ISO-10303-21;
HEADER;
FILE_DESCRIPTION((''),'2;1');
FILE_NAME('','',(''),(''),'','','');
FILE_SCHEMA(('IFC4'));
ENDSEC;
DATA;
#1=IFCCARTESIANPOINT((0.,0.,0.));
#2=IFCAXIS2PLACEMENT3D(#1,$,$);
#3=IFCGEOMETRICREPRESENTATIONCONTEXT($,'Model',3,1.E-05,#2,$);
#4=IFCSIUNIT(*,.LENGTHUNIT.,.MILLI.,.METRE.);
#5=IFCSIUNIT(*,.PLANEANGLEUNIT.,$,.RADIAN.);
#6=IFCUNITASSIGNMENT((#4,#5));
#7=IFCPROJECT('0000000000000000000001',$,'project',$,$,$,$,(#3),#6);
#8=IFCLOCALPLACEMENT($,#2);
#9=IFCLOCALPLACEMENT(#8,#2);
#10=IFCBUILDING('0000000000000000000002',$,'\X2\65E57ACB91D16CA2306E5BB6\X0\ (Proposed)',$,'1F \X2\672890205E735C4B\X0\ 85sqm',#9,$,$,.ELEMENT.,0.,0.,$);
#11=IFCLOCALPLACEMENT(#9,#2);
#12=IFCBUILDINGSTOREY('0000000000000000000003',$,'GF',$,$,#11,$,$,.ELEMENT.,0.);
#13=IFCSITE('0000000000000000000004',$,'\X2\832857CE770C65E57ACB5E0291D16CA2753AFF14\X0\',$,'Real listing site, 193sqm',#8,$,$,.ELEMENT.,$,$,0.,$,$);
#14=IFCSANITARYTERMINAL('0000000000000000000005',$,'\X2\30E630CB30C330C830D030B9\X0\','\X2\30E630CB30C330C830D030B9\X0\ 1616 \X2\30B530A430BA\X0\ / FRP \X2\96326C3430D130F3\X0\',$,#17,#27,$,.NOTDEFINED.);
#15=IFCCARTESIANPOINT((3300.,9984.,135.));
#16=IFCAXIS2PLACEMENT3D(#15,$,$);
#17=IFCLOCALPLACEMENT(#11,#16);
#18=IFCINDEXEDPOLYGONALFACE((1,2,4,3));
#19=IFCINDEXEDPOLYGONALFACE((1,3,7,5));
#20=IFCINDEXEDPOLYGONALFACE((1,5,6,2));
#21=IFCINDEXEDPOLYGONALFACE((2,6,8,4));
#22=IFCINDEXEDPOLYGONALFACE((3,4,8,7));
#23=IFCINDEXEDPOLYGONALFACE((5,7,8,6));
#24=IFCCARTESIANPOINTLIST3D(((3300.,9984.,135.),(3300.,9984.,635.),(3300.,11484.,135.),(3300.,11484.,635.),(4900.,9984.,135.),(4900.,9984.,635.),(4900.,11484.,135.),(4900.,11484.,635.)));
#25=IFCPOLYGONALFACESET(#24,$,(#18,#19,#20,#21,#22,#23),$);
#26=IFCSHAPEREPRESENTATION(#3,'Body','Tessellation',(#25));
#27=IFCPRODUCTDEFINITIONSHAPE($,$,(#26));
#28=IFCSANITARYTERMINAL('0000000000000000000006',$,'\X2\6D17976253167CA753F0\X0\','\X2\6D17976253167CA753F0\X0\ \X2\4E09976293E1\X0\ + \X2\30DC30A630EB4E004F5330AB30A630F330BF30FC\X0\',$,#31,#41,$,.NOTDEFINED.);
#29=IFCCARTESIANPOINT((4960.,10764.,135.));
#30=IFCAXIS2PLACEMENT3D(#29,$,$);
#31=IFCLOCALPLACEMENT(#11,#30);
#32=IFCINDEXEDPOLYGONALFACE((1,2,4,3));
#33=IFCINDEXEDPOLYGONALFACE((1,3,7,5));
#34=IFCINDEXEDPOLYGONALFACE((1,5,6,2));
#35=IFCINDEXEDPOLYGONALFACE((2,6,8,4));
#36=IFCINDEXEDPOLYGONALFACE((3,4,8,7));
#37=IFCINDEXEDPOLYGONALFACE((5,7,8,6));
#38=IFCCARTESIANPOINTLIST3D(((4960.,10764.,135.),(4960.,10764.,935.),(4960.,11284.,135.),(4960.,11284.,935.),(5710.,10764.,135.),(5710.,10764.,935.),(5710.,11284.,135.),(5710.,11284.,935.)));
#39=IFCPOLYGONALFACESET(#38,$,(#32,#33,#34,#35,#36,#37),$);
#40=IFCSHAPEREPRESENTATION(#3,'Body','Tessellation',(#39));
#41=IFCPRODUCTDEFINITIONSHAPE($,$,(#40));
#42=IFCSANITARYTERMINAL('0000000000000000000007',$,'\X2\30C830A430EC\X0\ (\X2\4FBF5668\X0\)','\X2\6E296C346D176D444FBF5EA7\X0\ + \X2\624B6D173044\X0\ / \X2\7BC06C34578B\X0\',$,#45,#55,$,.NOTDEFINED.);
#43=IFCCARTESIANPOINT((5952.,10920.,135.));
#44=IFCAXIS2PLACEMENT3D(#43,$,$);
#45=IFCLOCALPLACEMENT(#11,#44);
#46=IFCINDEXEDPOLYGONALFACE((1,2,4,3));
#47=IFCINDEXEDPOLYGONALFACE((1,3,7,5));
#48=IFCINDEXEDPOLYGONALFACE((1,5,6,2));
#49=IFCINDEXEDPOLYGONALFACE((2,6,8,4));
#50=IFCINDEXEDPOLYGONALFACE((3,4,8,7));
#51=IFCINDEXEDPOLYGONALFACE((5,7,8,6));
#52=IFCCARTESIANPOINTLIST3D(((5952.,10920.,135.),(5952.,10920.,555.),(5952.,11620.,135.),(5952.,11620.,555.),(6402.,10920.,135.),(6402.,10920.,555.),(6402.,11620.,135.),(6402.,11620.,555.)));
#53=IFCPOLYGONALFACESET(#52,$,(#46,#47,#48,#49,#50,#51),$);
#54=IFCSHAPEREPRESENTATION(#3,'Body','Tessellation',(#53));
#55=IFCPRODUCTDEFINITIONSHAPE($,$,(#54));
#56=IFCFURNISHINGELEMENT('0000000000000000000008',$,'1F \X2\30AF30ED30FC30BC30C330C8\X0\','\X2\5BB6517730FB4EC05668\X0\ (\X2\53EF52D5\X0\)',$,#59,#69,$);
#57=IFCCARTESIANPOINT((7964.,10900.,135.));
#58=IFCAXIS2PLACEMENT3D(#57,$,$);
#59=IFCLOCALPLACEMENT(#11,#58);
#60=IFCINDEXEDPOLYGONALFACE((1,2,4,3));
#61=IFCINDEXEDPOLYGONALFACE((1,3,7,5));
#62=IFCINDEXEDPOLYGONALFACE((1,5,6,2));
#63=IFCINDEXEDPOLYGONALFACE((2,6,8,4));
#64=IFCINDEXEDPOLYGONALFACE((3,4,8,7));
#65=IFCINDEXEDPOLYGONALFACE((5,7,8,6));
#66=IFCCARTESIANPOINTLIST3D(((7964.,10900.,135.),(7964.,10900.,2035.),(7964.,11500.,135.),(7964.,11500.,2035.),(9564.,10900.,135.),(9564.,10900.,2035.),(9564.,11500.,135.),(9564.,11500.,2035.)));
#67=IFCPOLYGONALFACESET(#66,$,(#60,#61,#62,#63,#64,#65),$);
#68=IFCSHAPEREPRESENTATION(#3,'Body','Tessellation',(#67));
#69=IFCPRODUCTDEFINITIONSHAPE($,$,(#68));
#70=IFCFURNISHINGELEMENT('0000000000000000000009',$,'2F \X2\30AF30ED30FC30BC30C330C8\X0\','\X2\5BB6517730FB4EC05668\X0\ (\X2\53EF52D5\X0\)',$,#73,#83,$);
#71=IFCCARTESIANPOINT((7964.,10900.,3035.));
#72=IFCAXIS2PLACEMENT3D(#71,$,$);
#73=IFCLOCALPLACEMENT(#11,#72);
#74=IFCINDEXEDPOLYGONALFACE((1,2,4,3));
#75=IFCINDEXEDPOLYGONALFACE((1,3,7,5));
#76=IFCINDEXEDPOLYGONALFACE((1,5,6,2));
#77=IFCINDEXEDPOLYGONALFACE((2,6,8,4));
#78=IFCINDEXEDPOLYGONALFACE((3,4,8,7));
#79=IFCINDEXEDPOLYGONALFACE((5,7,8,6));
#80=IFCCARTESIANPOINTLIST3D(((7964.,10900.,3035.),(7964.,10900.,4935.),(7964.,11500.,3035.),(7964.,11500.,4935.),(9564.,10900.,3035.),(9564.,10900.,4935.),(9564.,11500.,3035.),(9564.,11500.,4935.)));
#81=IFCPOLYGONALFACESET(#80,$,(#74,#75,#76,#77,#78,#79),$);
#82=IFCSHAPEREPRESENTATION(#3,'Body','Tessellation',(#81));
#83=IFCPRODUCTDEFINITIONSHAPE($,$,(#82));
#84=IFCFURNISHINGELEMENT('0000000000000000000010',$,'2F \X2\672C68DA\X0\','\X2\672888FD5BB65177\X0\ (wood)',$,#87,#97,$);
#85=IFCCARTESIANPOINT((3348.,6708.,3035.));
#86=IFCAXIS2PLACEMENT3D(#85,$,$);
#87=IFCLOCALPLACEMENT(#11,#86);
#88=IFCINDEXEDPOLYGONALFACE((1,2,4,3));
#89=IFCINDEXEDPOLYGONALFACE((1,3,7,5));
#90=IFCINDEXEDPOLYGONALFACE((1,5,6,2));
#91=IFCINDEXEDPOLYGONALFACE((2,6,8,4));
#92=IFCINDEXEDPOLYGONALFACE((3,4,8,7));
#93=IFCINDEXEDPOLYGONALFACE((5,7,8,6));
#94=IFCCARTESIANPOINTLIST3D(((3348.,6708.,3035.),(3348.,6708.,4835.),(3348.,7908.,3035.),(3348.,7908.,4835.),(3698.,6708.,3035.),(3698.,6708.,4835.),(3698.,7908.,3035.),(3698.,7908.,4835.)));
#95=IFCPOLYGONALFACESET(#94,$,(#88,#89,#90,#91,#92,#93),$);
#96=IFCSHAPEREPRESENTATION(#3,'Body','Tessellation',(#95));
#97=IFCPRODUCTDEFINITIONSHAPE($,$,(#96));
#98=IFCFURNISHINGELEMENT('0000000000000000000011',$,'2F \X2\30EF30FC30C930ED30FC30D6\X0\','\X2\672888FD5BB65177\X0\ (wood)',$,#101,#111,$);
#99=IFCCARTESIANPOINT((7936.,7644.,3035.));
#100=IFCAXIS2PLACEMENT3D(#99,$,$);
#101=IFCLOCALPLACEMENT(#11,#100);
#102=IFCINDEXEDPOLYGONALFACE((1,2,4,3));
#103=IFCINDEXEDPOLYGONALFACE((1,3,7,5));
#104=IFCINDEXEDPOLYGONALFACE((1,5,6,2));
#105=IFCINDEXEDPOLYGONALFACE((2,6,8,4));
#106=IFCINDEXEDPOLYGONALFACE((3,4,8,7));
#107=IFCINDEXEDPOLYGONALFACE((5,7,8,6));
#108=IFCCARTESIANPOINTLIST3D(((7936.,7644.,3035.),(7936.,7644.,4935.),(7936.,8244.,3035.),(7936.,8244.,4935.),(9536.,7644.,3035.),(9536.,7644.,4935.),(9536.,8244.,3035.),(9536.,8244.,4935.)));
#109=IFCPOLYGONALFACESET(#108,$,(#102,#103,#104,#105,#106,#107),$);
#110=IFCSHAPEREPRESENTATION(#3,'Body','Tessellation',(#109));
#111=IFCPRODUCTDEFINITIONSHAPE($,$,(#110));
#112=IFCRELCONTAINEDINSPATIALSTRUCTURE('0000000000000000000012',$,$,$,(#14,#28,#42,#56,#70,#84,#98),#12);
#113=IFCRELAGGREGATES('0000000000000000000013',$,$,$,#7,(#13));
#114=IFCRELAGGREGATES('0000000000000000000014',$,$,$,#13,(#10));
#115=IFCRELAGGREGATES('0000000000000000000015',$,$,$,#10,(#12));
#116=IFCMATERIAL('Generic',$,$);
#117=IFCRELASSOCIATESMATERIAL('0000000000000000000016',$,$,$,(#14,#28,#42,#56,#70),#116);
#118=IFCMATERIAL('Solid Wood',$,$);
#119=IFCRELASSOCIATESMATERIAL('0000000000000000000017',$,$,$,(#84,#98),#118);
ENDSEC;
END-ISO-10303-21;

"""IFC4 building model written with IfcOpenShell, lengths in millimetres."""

from ifc_helpers import new_model, si_unit, frame, frame_2d, origin, place, context, project, spatial, rectangle, extrude, material, element, save


model = new_model("IFC4")

# Units and contexts
model_context = context("Model", 3, precision=1e-05, world=origin())
ifc_project = project(units=[si_unit("LENGTHUNIT", "METRE", prefix="MILLI"), si_unit("PLANEANGLEUNIT", "RADIAN")], contexts=[model_context])

# Site, building, storey
site_placement = place(None, origin())
site = spatial("IfcSite", under=ifc_project, at=site_placement, Name="茨城県日立市金沢町４", ObjectType="Real listing site, 193sqm", CompositionType="ELEMENT", RefElevation=0.0)
building_placement = place(site_placement, origin())
building = spatial("IfcBuilding", under=site, at=building_placement, Name="日立金沢の家 (Proposed)", ObjectType="1F 木造平屋 85sqm", CompositionType="ELEMENT", ElevationOfRefHeight=0.0, ElevationOfTerrain=0.0)
storey_placement = place(building_placement, origin())
storey = spatial("IfcBuildingStorey", under=building, at=storey_placement, Name="GF", CompositionType="ELEMENT", Elevation=0.0)

# Shared definitions
ifc_material_1 = material(Name="Solid Wood")

# Shared definitions
ifc_material_2 = material(Name="Generic")

# Sanitary terminals
sanitary_terminal_1_placement = place(storey_placement, frame((3300.0, 9984.0, 135.0)))
element("IfcSanitaryTerminal", 1, at=sanitary_terminal_1_placement, inside=storey, material=ifc_material_2, Name="ユニットバス", Description="ユニットバス 1616 サイズ / FRP 防水パン", PredefinedType="NOTDEFINED", context=model_context, shape_type="SweptSolid", body=[
    extrude(rectangle(XDim=1600.0, YDim=1500.0, at=frame_2d((800.0, 750.0))), frame((3300.0, 9984.0, 135.0)), (0.0, 0.0, 1.0), 500.0),
])
sanitary_terminal_2_placement = place(storey_placement, frame((4960.0, 10764.0, 135.0)))
element("IfcSanitaryTerminal", 2, at=sanitary_terminal_2_placement, inside=storey, material=ifc_material_2, Name="洗面化粧台", Description="洗面化粧台 三面鏡 + ボウル一体カウンター", PredefinedType="NOTDEFINED", context=model_context, shape_type="SweptSolid", body=[
    extrude(rectangle(XDim=750.0, YDim=520.0, at=frame_2d((375.0, 260.0))), frame((4960.0, 10764.0, 135.0)), (0.0, 0.0, 1.0), 800.0),
])
sanitary_terminal_3_placement = place(storey_placement, frame((5952.0, 10920.0, 135.0)))
element("IfcSanitaryTerminal", 3, at=sanitary_terminal_3_placement, inside=storey, material=ifc_material_2, Name="トイレ (便器)", Description="温水洗浄便座 + 手洗い / 節水型", PredefinedType="NOTDEFINED", context=model_context, shape_type="SweptSolid", body=[
    extrude(rectangle(XDim=450.0, YDim=700.0, at=frame_2d((225.0, 350.0))), frame((5952.0, 10920.0, 135.0)), (0.0, 0.0, 1.0), 420.0),
])

# Furnishing elements
furnishing_1_placement = place(storey_placement, frame((7964.0, 10900.0, 135.0)))
element("IfcFurnishingElement", 4, at=furnishing_1_placement, inside=storey, material=ifc_material_2, Name="1F クローゼット", Description="家具・什器 (可動)", context=model_context, shape_type="SweptSolid", body=[
    extrude(rectangle(XDim=1600.0, YDim=600.0, at=frame_2d((800.0, 300.0))), frame((7964.0, 10900.0, 135.0)), (0.0, 0.0, 1.0), 1900.0),
])
furnishing_2_placement = place(storey_placement, frame((7964.0, 10900.0, 3035.0)))
element("IfcFurnishingElement", 5, at=furnishing_2_placement, inside=storey, material=ifc_material_2, Name="2F クローゼット", Description="家具・什器 (可動)", context=model_context, shape_type="SweptSolid", body=[
    extrude(rectangle(XDim=1600.0, YDim=600.0, at=frame_2d((800.0, 300.0))), frame((7964.0, 10900.0, 3035.0)), (0.0, 0.0, 1.0), 1900.0),
])
furnishing_3_placement = place(storey_placement, frame((3348.0, 6708.0, 3035.0)))
element("IfcFurnishingElement", 6, at=furnishing_3_placement, inside=storey, material=ifc_material_1, Name="2F 本棚", Description="木製家具 (wood)", context=model_context, shape_type="SweptSolid", body=[
    extrude(rectangle(XDim=350.0, YDim=1200.0, at=frame_2d((175.0, 600.0))), frame((3348.0, 6708.0, 3035.0)), (0.0, 0.0, 1.0), 1800.0),
])
furnishing_4_placement = place(storey_placement, frame((7936.0, 7644.0, 3035.0)))
element("IfcFurnishingElement", 7, at=furnishing_4_placement, inside=storey, material=ifc_material_1, Name="2F ワードローブ", Description="木製家具 (wood)", context=model_context, shape_type="SweptSolid", body=[
    extrude(rectangle(XDim=1600.0, YDim=600.0, at=frame_2d((800.0, 300.0))), frame((7936.0, 7644.0, 3035.0)), (0.0, 0.0, 1.0), 1900.0),
])

save(model, "model.ifc")
